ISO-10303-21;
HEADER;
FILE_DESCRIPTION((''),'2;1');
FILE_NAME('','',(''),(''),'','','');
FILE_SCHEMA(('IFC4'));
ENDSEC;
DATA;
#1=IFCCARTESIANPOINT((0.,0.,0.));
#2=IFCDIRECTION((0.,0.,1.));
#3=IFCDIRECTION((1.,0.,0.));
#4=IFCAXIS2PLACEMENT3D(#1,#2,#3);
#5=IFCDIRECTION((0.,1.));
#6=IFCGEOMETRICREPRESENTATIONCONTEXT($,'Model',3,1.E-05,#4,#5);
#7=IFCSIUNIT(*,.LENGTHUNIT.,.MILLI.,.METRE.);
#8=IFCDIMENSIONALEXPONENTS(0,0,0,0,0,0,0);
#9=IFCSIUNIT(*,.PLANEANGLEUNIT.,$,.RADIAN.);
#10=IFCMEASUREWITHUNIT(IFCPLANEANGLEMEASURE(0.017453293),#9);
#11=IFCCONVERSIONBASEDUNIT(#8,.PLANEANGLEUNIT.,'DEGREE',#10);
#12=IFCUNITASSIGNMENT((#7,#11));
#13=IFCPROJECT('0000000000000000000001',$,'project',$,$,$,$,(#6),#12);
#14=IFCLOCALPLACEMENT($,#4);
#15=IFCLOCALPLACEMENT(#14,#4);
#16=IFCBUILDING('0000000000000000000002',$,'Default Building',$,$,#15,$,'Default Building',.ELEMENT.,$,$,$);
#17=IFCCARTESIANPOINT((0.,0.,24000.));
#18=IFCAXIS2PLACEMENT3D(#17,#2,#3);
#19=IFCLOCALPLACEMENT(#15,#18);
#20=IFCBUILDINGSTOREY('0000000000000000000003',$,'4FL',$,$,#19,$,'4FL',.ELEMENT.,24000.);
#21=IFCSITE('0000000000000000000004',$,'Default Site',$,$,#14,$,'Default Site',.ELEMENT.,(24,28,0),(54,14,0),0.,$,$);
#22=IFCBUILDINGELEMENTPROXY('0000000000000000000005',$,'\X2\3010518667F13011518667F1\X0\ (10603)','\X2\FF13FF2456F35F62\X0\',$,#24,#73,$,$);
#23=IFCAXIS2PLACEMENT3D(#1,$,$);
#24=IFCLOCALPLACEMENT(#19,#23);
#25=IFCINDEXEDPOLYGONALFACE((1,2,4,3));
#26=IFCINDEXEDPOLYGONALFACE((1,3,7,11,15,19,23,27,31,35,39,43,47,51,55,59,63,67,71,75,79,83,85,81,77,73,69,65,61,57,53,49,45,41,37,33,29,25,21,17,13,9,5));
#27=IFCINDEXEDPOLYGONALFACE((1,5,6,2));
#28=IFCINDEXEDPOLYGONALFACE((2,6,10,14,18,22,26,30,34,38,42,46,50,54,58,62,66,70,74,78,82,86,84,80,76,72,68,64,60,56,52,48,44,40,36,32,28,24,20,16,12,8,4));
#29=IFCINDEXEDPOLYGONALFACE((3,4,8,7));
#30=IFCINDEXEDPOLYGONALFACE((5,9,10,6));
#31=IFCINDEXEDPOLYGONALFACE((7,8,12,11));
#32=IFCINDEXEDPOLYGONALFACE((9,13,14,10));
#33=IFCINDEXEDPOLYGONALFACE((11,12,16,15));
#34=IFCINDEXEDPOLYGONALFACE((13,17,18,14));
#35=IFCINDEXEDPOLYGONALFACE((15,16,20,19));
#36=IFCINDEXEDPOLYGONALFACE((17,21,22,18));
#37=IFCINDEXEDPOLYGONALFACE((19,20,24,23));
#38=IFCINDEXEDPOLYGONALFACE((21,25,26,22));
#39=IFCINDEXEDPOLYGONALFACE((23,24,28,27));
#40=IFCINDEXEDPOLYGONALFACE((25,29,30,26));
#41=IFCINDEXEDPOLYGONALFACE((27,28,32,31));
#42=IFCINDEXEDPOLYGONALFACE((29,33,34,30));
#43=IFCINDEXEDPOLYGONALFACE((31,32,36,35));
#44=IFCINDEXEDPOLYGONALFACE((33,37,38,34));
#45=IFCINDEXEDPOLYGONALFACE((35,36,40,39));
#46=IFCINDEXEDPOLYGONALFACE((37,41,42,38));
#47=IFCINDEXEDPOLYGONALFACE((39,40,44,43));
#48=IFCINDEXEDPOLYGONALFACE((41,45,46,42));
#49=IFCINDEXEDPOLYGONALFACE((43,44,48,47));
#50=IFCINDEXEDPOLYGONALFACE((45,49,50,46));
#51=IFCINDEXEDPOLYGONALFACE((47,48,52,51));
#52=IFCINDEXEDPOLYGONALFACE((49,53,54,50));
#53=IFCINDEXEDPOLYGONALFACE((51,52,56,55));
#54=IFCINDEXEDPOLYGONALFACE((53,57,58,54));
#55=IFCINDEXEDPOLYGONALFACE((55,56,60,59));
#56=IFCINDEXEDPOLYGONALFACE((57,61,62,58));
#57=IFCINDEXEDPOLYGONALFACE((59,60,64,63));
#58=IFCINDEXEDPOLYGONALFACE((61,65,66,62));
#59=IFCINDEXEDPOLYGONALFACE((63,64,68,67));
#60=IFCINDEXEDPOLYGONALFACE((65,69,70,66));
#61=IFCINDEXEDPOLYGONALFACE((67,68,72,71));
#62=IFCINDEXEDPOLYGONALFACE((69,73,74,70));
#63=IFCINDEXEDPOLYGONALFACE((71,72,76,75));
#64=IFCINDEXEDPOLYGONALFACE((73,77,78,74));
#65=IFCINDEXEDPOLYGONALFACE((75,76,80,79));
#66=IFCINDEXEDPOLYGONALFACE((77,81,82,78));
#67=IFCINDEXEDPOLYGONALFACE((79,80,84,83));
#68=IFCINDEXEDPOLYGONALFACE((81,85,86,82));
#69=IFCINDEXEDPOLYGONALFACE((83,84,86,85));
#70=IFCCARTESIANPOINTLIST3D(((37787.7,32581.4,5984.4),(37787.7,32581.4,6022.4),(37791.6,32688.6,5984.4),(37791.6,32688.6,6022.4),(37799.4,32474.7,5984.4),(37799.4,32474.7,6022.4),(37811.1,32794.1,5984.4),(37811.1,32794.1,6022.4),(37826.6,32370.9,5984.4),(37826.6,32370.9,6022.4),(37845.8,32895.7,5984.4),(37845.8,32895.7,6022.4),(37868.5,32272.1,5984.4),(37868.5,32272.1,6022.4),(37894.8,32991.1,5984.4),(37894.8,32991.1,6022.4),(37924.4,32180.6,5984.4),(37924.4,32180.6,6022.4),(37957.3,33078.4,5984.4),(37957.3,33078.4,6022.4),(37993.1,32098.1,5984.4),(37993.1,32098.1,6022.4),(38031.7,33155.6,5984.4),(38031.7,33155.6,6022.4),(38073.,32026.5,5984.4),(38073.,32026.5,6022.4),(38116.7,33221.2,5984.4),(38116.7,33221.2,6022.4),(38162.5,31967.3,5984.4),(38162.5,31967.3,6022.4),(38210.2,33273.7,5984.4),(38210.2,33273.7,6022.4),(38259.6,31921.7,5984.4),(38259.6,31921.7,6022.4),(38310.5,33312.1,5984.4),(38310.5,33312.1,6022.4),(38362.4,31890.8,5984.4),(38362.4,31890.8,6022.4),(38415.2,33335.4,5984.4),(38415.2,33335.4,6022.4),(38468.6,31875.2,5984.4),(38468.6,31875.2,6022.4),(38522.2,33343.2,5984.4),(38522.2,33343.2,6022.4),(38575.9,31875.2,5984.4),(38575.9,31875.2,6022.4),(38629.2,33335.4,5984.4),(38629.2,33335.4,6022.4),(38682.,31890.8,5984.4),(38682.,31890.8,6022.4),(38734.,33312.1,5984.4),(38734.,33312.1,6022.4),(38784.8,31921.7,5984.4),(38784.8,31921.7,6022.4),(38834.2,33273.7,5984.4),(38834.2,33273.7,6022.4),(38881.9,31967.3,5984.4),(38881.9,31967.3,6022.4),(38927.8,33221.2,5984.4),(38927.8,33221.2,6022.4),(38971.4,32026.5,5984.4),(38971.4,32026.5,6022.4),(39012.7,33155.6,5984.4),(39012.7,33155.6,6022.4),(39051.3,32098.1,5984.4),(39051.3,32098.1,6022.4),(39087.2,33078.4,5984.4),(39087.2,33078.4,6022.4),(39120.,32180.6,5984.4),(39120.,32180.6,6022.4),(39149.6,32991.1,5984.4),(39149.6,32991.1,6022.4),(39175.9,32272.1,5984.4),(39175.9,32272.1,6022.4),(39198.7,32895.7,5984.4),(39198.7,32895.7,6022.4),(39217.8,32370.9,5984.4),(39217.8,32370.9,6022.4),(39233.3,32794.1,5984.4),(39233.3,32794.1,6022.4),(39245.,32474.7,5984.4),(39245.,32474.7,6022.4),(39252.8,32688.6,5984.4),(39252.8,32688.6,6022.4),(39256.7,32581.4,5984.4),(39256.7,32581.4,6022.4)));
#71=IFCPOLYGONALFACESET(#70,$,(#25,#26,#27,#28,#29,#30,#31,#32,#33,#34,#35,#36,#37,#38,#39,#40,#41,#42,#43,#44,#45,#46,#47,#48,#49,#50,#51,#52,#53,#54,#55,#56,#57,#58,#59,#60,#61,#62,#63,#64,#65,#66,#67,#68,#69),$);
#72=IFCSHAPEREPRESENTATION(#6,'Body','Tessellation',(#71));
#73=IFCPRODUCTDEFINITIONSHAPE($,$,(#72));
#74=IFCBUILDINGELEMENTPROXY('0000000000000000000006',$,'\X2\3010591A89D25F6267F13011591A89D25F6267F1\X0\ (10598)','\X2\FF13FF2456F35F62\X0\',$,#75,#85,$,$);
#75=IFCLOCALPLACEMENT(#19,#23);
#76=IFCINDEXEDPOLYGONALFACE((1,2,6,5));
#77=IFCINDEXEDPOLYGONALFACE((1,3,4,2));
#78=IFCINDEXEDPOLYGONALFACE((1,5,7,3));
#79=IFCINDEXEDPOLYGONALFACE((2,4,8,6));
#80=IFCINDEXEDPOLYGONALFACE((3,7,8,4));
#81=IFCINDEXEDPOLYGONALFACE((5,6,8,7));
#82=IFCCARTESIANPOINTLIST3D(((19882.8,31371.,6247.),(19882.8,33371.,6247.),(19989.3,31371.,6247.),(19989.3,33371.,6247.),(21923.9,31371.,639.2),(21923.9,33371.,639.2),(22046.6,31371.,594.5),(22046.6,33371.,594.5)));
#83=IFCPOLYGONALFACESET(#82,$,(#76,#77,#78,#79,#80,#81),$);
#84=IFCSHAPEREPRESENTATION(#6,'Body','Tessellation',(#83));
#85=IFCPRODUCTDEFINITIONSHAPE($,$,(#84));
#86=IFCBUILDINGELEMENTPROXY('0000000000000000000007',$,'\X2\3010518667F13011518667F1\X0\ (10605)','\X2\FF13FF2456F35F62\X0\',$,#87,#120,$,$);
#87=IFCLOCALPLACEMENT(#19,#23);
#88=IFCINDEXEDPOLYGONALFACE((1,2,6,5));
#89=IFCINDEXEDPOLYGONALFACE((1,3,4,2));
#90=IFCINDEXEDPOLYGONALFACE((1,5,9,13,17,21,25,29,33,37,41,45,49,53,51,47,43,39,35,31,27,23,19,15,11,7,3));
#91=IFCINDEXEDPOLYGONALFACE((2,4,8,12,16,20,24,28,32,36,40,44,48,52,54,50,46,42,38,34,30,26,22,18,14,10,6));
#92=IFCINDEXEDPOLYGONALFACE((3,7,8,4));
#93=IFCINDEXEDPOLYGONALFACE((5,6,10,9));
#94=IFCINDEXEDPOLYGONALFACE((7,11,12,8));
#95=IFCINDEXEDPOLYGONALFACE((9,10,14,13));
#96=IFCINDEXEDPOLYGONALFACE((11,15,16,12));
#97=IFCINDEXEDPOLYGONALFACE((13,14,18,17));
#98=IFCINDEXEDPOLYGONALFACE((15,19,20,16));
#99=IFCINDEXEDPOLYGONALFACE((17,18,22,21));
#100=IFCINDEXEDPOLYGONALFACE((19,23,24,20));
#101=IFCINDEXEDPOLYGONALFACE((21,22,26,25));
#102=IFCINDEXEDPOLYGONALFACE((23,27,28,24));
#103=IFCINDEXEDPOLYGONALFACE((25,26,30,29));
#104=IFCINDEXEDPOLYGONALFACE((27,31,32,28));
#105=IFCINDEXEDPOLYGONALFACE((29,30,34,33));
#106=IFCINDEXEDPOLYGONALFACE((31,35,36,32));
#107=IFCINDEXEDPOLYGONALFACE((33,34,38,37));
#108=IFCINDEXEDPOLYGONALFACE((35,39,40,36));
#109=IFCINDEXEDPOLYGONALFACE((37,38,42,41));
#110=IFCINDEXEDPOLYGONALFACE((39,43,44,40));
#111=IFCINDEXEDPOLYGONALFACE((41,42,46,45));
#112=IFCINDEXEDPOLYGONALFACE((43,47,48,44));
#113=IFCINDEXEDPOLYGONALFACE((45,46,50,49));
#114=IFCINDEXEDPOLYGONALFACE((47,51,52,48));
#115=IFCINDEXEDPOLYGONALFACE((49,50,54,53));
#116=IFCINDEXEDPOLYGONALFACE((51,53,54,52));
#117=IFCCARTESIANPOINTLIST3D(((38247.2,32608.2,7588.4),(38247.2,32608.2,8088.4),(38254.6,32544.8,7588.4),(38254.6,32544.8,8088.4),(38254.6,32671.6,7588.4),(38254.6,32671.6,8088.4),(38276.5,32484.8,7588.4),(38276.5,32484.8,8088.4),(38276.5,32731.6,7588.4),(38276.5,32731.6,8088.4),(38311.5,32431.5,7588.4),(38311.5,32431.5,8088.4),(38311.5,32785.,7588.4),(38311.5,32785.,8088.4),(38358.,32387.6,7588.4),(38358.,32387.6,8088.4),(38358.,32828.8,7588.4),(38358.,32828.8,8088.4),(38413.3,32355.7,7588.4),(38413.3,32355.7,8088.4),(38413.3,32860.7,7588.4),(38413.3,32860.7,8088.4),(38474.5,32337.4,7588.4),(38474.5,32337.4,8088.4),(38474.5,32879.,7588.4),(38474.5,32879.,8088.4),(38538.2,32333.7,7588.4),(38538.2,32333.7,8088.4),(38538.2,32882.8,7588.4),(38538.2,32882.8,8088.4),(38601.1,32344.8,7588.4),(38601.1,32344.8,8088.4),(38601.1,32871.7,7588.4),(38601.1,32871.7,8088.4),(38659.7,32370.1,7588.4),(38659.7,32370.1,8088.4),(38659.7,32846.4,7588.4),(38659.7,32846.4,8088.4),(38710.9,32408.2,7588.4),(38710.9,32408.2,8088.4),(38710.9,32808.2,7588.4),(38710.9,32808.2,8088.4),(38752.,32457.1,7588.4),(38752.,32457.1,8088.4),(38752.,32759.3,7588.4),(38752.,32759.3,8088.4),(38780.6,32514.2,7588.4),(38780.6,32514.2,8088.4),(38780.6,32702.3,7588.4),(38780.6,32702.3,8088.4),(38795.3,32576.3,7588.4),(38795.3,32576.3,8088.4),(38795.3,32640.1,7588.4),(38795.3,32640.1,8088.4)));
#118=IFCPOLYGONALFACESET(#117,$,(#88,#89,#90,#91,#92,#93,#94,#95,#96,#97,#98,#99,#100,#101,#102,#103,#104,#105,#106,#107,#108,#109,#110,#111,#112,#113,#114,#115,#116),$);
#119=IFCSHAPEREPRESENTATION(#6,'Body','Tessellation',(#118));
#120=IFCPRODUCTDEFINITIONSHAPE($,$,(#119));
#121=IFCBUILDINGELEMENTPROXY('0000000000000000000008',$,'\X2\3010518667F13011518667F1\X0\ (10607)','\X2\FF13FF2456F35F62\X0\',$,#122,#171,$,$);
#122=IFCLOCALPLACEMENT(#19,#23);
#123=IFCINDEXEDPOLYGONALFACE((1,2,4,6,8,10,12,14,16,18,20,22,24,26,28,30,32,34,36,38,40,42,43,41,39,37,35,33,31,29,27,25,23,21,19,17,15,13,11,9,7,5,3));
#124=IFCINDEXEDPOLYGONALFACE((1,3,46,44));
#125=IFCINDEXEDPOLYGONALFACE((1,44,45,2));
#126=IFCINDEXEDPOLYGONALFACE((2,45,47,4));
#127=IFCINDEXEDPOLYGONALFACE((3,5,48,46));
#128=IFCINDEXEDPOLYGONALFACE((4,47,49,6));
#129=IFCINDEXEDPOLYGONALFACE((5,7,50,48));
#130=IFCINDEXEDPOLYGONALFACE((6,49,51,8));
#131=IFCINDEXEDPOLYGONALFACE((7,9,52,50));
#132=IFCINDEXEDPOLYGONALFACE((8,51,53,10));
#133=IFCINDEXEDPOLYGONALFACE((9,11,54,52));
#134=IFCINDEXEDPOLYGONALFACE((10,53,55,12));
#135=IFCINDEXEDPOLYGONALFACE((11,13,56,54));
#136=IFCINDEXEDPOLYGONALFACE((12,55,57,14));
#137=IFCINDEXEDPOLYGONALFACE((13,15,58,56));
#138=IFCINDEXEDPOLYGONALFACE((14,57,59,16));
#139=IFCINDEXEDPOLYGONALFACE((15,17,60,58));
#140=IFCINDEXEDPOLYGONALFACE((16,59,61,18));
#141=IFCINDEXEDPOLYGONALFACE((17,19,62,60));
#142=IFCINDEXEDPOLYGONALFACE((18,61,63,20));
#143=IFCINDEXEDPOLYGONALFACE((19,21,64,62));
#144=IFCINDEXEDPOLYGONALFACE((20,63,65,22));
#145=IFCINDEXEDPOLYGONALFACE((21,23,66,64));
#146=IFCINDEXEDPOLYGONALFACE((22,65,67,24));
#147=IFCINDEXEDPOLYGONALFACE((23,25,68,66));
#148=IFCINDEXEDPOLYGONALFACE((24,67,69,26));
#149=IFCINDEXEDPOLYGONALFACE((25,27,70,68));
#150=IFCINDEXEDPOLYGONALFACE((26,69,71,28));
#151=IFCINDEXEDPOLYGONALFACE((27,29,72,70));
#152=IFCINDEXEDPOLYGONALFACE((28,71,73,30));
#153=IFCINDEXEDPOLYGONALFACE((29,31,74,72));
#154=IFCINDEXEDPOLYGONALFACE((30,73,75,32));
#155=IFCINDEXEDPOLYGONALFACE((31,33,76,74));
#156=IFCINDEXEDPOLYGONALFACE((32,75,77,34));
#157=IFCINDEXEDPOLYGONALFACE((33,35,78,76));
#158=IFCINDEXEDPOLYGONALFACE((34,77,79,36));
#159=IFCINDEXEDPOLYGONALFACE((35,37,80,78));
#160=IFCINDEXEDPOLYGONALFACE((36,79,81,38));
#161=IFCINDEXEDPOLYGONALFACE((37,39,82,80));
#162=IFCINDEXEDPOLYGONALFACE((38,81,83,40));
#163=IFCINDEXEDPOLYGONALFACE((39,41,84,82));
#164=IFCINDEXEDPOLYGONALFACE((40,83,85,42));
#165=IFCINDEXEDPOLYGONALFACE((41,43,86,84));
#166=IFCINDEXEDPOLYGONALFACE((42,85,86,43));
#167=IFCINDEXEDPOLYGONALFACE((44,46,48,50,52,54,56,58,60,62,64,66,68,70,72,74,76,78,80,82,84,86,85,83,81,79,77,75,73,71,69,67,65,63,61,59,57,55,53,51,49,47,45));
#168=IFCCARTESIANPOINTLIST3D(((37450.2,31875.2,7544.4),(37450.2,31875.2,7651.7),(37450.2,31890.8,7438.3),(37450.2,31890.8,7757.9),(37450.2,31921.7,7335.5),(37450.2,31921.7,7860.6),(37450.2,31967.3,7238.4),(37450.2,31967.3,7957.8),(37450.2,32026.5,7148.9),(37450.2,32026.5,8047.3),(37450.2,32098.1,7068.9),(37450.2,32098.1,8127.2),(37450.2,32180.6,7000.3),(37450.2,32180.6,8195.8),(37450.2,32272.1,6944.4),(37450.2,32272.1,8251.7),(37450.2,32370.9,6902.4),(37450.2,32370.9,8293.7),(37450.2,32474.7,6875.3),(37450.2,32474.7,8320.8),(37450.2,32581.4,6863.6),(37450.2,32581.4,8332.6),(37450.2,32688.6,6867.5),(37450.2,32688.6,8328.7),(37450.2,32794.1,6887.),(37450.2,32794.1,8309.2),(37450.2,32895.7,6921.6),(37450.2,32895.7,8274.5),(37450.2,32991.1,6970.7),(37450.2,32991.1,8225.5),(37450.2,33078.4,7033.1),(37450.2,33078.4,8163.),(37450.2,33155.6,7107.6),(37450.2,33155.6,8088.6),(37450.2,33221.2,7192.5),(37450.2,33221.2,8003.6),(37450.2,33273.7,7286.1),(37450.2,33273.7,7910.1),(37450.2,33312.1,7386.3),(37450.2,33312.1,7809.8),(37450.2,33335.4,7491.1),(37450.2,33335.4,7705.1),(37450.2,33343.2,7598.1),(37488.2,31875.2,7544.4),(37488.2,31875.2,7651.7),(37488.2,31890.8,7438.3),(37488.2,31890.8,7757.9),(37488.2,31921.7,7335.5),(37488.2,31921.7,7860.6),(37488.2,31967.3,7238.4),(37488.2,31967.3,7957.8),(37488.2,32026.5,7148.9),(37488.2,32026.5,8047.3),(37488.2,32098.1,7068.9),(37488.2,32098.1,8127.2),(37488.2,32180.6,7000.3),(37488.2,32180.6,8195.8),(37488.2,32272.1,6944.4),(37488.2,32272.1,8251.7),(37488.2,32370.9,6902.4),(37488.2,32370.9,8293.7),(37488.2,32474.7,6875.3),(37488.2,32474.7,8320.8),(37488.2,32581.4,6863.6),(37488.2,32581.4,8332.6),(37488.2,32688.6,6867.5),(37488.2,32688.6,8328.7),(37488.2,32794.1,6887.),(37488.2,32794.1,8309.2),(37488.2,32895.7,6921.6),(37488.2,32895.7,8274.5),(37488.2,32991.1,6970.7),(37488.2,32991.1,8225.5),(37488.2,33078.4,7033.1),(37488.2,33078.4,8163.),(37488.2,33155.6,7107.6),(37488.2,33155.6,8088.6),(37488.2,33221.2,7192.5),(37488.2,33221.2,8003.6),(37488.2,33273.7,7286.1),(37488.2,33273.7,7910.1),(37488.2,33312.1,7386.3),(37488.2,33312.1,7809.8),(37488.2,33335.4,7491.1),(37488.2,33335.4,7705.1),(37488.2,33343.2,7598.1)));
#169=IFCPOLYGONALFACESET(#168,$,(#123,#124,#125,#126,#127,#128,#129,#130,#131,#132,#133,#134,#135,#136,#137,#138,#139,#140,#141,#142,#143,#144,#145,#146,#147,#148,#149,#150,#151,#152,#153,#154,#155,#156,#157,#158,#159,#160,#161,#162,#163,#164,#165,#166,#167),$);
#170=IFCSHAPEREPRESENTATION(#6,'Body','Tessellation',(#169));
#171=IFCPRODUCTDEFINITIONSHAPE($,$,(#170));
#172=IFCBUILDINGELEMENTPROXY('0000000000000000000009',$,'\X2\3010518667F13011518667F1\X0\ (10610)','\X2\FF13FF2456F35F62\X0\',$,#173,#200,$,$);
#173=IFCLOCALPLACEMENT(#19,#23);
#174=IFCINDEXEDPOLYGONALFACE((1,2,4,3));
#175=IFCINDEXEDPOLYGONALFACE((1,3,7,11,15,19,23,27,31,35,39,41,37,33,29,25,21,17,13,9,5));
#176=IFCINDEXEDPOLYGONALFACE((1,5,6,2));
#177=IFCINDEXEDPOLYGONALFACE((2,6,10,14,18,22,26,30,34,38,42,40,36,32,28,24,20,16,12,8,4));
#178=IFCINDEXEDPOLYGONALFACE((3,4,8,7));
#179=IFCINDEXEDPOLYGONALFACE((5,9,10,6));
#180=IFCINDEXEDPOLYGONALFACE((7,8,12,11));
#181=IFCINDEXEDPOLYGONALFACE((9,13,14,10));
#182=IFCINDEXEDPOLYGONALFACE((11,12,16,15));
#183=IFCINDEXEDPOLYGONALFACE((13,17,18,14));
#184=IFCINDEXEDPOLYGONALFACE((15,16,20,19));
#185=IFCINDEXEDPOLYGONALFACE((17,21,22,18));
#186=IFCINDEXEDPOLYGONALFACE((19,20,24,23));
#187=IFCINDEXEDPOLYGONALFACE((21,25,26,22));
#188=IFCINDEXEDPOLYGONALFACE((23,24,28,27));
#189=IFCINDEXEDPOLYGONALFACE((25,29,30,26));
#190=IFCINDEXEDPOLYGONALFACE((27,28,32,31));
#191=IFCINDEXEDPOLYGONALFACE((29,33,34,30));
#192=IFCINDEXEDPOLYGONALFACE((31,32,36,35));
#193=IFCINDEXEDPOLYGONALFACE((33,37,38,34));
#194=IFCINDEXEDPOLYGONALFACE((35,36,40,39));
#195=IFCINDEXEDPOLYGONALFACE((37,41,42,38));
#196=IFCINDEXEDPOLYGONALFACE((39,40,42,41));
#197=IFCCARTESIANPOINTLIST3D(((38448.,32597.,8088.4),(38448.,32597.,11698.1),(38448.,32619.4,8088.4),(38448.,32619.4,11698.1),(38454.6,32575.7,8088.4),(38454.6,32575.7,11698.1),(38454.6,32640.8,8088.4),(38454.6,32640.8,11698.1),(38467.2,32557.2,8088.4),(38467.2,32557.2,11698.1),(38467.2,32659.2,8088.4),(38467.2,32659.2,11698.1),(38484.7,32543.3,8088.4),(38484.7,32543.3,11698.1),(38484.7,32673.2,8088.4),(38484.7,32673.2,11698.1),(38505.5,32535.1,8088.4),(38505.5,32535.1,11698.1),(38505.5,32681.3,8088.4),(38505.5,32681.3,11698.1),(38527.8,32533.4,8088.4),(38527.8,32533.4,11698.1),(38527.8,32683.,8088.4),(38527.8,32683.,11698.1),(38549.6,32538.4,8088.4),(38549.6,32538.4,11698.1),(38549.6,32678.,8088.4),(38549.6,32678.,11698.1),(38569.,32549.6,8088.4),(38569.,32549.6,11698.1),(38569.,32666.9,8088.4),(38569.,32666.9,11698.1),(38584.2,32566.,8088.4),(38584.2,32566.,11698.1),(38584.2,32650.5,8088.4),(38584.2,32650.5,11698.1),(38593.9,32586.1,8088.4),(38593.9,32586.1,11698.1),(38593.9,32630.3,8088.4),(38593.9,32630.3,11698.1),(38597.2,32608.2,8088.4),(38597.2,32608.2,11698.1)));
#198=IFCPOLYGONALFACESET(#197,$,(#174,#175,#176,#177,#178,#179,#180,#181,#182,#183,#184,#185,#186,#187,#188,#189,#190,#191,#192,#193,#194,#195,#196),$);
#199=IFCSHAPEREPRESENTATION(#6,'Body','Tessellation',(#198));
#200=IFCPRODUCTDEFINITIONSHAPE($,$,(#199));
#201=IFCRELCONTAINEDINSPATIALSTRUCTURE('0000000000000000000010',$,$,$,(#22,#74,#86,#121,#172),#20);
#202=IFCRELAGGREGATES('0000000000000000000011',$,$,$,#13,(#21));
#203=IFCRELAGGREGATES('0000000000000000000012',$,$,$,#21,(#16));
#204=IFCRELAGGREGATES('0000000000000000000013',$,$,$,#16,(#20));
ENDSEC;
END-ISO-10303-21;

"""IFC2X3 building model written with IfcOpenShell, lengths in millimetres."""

from ifc_helpers import new_model, entity, si_unit, converted_unit, direction, frame, origin_with_axes, origin_2d_with_axis, place, context, project, spatial, polyline, circle, outline, extrude, source, transform, mapped, element, save


model = new_model("IFC2X3")

# Units and contexts
model_context = context("Model", 3, precision=1e-05, world=origin_with_axes(), true_north=direction((0.0, 1.0)))
ifc_project = project(units=[si_unit("LENGTHUNIT", "METRE", prefix="MILLI"), converted_unit("PLANEANGLEUNIT", "DEGREE", entity("IfcPlaneAngleMeasure", 0.017453293), si_unit("PLANEANGLEUNIT", "RADIAN"), dimensions=[0, 0, 0, 0, 0, 0, 0])], contexts=[model_context])

# Site, building, storey
site_placement = place(None, origin_with_axes())
site = spatial("IfcSite", under=ifc_project, at=site_placement, Name="Default Site", LongName="Default Site", CompositionType="ELEMENT", RefLatitude=(24, 28, 0), RefLongitude=(54, 14, 0), RefElevation=0.0)
building_placement = place(site_placement, origin_with_axes())
building = spatial("IfcBuilding", under=site, at=building_placement, Name="Default Building", LongName="Default Building", CompositionType="ELEMENT")
storey_placement = place(building_placement, frame((0.0, 0.0, 24000.0), z_axis=(0.0, 0.0, 1.0), x_axis=(1.0, 0.0, 0.0)))
storey = spatial("IfcBuildingStorey", under=building, at=storey_placement, Name="4FL", LongName="4FL", CompositionType="ELEMENT", Elevation=24000.0)

# Building element proxies
shared_shape_1 = source(origin_with_axes(), model_context, "Body", "SweptSolid", [
    extrude(circle(Radius=735.0, at=origin_2d_with_axis()), frame((0.0, 0.0, 0.0), z_axis=(0.0, 0.0, 1.0), x_axis=(1.0, 0.0, 0.0)), (0.0, 0.0, 1.0), 38.0),
])
proxy_1_placement = place(storey_placement, frame((38522.2, 32608.2, 6022.4), z_axis=(0.0, 0.0, -1.0), x_axis=(0.0, 1.0, 0.0)))
element("IfcBuildingElementProxy", 1, at=proxy_1_placement, inside=storey, Name="【円柱】円柱 (10603)", Description="３Ｄ図形", context=model_context, shape_type="MappedRepresentation", body=[
    mapped(shared_shape_1, transform((0.0, 0.0, 0.0))),
])
shared_shape_2 = source(origin_with_axes(), model_context, "Body", "SweptSolid", [
    extrude(outline(polyline([(1081.9, 2826.2), (975.4, 2826.2), (-1081.9, -2826.2), (-959.2, -2781.6), (1081.9, 2826.2)])), frame((0.0, 0.0, 0.0), z_axis=(0.0, 0.0, 1.0), x_axis=(1.0, 0.0, 0.0)), (0.0, 0.0, 1.0), 2000.0),
])
proxy_2_placement = place(storey_placement, frame((20964.7, 31371.0, 3420.7), z_axis=(0.0, 1.0, 0.0), x_axis=(-1.0, 0.0, 0.0)))
element("IfcBuildingElementProxy", 2, at=proxy_2_placement, inside=storey, Name="【多角形柱】多角形柱 (10598)", Description="３Ｄ図形", context=model_context, shape_type="MappedRepresentation", body=[
    mapped(shared_shape_2, transform((0.0, 0.0, 0.0))),
])
shared_shape_3 = source(origin_with_axes(), model_context, "Body", "SweptSolid", [
    extrude(circle(Radius=275.0, at=origin_2d_with_axis()), frame((0.0, 0.0, 0.0), z_axis=(0.0, 0.0, 1.0), x_axis=(1.0, 0.0, 0.0)), (0.0, 0.0, 1.0), 500.0),
])
proxy_3_placement = place(storey_placement, frame((38522.2, 32608.2, 8088.4), z_axis=(0.0, 0.0, -1.0), x_axis=(-1.0, 0.0, 0.0)))
element("IfcBuildingElementProxy", 3, at=proxy_3_placement, inside=storey, Name="【円柱】円柱 (10605)", Description="３Ｄ図形", context=model_context, shape_type="MappedRepresentation", body=[
    mapped(shared_shape_3, transform((0.0, 0.0, 0.0))),
])
shared_shape_4 = source(origin_with_axes(), model_context, "Body", "SweptSolid", [
    extrude(circle(Radius=735.0, at=origin_2d_with_axis()), frame((0.0, 0.0, 0.0), z_axis=(0.0, 0.0, 1.0), x_axis=(1.0, 0.0, 0.0)), (0.0, 0.0, 1.0), 38.0),
])
proxy_4_placement = place(storey_placement, frame((37488.2, 32608.2, 7598.1), z_axis=(-1.0, 0.0, 0.0), x_axis=(0.0, 1.0, 0.0)))
element("IfcBuildingElementProxy", 4, at=proxy_4_placement, inside=storey, Name="【円柱】円柱 (10607)", Description="３Ｄ図形", context=model_context, shape_type="MappedRepresentation", body=[
    mapped(shared_shape_4, transform((0.0, 0.0, 0.0))),
])
shared_shape_5 = source(origin_with_axes(), model_context, "Body", "SweptSolid", [
    extrude(circle(Radius=75.0, at=origin_2d_with_axis()), origin_with_axes(), (0.0, 0.0, 1.0), 3609.7),
])
proxy_5_placement = place(storey_placement, frame((38522.2, 32608.2, 8088.4), z_axis=(0.0, 0.0, 1.0), x_axis=(1.0, 0.0, 0.0)))
element("IfcBuildingElementProxy", 5, at=proxy_5_placement, inside=storey, Name="【円柱】円柱 (10610)", Description="３Ｄ図形", context=model_context, shape_type="MappedRepresentation", body=[
    mapped(shared_shape_5, transform((0.0, 0.0, 0.0))),
])

save(model, "model.ifc")
